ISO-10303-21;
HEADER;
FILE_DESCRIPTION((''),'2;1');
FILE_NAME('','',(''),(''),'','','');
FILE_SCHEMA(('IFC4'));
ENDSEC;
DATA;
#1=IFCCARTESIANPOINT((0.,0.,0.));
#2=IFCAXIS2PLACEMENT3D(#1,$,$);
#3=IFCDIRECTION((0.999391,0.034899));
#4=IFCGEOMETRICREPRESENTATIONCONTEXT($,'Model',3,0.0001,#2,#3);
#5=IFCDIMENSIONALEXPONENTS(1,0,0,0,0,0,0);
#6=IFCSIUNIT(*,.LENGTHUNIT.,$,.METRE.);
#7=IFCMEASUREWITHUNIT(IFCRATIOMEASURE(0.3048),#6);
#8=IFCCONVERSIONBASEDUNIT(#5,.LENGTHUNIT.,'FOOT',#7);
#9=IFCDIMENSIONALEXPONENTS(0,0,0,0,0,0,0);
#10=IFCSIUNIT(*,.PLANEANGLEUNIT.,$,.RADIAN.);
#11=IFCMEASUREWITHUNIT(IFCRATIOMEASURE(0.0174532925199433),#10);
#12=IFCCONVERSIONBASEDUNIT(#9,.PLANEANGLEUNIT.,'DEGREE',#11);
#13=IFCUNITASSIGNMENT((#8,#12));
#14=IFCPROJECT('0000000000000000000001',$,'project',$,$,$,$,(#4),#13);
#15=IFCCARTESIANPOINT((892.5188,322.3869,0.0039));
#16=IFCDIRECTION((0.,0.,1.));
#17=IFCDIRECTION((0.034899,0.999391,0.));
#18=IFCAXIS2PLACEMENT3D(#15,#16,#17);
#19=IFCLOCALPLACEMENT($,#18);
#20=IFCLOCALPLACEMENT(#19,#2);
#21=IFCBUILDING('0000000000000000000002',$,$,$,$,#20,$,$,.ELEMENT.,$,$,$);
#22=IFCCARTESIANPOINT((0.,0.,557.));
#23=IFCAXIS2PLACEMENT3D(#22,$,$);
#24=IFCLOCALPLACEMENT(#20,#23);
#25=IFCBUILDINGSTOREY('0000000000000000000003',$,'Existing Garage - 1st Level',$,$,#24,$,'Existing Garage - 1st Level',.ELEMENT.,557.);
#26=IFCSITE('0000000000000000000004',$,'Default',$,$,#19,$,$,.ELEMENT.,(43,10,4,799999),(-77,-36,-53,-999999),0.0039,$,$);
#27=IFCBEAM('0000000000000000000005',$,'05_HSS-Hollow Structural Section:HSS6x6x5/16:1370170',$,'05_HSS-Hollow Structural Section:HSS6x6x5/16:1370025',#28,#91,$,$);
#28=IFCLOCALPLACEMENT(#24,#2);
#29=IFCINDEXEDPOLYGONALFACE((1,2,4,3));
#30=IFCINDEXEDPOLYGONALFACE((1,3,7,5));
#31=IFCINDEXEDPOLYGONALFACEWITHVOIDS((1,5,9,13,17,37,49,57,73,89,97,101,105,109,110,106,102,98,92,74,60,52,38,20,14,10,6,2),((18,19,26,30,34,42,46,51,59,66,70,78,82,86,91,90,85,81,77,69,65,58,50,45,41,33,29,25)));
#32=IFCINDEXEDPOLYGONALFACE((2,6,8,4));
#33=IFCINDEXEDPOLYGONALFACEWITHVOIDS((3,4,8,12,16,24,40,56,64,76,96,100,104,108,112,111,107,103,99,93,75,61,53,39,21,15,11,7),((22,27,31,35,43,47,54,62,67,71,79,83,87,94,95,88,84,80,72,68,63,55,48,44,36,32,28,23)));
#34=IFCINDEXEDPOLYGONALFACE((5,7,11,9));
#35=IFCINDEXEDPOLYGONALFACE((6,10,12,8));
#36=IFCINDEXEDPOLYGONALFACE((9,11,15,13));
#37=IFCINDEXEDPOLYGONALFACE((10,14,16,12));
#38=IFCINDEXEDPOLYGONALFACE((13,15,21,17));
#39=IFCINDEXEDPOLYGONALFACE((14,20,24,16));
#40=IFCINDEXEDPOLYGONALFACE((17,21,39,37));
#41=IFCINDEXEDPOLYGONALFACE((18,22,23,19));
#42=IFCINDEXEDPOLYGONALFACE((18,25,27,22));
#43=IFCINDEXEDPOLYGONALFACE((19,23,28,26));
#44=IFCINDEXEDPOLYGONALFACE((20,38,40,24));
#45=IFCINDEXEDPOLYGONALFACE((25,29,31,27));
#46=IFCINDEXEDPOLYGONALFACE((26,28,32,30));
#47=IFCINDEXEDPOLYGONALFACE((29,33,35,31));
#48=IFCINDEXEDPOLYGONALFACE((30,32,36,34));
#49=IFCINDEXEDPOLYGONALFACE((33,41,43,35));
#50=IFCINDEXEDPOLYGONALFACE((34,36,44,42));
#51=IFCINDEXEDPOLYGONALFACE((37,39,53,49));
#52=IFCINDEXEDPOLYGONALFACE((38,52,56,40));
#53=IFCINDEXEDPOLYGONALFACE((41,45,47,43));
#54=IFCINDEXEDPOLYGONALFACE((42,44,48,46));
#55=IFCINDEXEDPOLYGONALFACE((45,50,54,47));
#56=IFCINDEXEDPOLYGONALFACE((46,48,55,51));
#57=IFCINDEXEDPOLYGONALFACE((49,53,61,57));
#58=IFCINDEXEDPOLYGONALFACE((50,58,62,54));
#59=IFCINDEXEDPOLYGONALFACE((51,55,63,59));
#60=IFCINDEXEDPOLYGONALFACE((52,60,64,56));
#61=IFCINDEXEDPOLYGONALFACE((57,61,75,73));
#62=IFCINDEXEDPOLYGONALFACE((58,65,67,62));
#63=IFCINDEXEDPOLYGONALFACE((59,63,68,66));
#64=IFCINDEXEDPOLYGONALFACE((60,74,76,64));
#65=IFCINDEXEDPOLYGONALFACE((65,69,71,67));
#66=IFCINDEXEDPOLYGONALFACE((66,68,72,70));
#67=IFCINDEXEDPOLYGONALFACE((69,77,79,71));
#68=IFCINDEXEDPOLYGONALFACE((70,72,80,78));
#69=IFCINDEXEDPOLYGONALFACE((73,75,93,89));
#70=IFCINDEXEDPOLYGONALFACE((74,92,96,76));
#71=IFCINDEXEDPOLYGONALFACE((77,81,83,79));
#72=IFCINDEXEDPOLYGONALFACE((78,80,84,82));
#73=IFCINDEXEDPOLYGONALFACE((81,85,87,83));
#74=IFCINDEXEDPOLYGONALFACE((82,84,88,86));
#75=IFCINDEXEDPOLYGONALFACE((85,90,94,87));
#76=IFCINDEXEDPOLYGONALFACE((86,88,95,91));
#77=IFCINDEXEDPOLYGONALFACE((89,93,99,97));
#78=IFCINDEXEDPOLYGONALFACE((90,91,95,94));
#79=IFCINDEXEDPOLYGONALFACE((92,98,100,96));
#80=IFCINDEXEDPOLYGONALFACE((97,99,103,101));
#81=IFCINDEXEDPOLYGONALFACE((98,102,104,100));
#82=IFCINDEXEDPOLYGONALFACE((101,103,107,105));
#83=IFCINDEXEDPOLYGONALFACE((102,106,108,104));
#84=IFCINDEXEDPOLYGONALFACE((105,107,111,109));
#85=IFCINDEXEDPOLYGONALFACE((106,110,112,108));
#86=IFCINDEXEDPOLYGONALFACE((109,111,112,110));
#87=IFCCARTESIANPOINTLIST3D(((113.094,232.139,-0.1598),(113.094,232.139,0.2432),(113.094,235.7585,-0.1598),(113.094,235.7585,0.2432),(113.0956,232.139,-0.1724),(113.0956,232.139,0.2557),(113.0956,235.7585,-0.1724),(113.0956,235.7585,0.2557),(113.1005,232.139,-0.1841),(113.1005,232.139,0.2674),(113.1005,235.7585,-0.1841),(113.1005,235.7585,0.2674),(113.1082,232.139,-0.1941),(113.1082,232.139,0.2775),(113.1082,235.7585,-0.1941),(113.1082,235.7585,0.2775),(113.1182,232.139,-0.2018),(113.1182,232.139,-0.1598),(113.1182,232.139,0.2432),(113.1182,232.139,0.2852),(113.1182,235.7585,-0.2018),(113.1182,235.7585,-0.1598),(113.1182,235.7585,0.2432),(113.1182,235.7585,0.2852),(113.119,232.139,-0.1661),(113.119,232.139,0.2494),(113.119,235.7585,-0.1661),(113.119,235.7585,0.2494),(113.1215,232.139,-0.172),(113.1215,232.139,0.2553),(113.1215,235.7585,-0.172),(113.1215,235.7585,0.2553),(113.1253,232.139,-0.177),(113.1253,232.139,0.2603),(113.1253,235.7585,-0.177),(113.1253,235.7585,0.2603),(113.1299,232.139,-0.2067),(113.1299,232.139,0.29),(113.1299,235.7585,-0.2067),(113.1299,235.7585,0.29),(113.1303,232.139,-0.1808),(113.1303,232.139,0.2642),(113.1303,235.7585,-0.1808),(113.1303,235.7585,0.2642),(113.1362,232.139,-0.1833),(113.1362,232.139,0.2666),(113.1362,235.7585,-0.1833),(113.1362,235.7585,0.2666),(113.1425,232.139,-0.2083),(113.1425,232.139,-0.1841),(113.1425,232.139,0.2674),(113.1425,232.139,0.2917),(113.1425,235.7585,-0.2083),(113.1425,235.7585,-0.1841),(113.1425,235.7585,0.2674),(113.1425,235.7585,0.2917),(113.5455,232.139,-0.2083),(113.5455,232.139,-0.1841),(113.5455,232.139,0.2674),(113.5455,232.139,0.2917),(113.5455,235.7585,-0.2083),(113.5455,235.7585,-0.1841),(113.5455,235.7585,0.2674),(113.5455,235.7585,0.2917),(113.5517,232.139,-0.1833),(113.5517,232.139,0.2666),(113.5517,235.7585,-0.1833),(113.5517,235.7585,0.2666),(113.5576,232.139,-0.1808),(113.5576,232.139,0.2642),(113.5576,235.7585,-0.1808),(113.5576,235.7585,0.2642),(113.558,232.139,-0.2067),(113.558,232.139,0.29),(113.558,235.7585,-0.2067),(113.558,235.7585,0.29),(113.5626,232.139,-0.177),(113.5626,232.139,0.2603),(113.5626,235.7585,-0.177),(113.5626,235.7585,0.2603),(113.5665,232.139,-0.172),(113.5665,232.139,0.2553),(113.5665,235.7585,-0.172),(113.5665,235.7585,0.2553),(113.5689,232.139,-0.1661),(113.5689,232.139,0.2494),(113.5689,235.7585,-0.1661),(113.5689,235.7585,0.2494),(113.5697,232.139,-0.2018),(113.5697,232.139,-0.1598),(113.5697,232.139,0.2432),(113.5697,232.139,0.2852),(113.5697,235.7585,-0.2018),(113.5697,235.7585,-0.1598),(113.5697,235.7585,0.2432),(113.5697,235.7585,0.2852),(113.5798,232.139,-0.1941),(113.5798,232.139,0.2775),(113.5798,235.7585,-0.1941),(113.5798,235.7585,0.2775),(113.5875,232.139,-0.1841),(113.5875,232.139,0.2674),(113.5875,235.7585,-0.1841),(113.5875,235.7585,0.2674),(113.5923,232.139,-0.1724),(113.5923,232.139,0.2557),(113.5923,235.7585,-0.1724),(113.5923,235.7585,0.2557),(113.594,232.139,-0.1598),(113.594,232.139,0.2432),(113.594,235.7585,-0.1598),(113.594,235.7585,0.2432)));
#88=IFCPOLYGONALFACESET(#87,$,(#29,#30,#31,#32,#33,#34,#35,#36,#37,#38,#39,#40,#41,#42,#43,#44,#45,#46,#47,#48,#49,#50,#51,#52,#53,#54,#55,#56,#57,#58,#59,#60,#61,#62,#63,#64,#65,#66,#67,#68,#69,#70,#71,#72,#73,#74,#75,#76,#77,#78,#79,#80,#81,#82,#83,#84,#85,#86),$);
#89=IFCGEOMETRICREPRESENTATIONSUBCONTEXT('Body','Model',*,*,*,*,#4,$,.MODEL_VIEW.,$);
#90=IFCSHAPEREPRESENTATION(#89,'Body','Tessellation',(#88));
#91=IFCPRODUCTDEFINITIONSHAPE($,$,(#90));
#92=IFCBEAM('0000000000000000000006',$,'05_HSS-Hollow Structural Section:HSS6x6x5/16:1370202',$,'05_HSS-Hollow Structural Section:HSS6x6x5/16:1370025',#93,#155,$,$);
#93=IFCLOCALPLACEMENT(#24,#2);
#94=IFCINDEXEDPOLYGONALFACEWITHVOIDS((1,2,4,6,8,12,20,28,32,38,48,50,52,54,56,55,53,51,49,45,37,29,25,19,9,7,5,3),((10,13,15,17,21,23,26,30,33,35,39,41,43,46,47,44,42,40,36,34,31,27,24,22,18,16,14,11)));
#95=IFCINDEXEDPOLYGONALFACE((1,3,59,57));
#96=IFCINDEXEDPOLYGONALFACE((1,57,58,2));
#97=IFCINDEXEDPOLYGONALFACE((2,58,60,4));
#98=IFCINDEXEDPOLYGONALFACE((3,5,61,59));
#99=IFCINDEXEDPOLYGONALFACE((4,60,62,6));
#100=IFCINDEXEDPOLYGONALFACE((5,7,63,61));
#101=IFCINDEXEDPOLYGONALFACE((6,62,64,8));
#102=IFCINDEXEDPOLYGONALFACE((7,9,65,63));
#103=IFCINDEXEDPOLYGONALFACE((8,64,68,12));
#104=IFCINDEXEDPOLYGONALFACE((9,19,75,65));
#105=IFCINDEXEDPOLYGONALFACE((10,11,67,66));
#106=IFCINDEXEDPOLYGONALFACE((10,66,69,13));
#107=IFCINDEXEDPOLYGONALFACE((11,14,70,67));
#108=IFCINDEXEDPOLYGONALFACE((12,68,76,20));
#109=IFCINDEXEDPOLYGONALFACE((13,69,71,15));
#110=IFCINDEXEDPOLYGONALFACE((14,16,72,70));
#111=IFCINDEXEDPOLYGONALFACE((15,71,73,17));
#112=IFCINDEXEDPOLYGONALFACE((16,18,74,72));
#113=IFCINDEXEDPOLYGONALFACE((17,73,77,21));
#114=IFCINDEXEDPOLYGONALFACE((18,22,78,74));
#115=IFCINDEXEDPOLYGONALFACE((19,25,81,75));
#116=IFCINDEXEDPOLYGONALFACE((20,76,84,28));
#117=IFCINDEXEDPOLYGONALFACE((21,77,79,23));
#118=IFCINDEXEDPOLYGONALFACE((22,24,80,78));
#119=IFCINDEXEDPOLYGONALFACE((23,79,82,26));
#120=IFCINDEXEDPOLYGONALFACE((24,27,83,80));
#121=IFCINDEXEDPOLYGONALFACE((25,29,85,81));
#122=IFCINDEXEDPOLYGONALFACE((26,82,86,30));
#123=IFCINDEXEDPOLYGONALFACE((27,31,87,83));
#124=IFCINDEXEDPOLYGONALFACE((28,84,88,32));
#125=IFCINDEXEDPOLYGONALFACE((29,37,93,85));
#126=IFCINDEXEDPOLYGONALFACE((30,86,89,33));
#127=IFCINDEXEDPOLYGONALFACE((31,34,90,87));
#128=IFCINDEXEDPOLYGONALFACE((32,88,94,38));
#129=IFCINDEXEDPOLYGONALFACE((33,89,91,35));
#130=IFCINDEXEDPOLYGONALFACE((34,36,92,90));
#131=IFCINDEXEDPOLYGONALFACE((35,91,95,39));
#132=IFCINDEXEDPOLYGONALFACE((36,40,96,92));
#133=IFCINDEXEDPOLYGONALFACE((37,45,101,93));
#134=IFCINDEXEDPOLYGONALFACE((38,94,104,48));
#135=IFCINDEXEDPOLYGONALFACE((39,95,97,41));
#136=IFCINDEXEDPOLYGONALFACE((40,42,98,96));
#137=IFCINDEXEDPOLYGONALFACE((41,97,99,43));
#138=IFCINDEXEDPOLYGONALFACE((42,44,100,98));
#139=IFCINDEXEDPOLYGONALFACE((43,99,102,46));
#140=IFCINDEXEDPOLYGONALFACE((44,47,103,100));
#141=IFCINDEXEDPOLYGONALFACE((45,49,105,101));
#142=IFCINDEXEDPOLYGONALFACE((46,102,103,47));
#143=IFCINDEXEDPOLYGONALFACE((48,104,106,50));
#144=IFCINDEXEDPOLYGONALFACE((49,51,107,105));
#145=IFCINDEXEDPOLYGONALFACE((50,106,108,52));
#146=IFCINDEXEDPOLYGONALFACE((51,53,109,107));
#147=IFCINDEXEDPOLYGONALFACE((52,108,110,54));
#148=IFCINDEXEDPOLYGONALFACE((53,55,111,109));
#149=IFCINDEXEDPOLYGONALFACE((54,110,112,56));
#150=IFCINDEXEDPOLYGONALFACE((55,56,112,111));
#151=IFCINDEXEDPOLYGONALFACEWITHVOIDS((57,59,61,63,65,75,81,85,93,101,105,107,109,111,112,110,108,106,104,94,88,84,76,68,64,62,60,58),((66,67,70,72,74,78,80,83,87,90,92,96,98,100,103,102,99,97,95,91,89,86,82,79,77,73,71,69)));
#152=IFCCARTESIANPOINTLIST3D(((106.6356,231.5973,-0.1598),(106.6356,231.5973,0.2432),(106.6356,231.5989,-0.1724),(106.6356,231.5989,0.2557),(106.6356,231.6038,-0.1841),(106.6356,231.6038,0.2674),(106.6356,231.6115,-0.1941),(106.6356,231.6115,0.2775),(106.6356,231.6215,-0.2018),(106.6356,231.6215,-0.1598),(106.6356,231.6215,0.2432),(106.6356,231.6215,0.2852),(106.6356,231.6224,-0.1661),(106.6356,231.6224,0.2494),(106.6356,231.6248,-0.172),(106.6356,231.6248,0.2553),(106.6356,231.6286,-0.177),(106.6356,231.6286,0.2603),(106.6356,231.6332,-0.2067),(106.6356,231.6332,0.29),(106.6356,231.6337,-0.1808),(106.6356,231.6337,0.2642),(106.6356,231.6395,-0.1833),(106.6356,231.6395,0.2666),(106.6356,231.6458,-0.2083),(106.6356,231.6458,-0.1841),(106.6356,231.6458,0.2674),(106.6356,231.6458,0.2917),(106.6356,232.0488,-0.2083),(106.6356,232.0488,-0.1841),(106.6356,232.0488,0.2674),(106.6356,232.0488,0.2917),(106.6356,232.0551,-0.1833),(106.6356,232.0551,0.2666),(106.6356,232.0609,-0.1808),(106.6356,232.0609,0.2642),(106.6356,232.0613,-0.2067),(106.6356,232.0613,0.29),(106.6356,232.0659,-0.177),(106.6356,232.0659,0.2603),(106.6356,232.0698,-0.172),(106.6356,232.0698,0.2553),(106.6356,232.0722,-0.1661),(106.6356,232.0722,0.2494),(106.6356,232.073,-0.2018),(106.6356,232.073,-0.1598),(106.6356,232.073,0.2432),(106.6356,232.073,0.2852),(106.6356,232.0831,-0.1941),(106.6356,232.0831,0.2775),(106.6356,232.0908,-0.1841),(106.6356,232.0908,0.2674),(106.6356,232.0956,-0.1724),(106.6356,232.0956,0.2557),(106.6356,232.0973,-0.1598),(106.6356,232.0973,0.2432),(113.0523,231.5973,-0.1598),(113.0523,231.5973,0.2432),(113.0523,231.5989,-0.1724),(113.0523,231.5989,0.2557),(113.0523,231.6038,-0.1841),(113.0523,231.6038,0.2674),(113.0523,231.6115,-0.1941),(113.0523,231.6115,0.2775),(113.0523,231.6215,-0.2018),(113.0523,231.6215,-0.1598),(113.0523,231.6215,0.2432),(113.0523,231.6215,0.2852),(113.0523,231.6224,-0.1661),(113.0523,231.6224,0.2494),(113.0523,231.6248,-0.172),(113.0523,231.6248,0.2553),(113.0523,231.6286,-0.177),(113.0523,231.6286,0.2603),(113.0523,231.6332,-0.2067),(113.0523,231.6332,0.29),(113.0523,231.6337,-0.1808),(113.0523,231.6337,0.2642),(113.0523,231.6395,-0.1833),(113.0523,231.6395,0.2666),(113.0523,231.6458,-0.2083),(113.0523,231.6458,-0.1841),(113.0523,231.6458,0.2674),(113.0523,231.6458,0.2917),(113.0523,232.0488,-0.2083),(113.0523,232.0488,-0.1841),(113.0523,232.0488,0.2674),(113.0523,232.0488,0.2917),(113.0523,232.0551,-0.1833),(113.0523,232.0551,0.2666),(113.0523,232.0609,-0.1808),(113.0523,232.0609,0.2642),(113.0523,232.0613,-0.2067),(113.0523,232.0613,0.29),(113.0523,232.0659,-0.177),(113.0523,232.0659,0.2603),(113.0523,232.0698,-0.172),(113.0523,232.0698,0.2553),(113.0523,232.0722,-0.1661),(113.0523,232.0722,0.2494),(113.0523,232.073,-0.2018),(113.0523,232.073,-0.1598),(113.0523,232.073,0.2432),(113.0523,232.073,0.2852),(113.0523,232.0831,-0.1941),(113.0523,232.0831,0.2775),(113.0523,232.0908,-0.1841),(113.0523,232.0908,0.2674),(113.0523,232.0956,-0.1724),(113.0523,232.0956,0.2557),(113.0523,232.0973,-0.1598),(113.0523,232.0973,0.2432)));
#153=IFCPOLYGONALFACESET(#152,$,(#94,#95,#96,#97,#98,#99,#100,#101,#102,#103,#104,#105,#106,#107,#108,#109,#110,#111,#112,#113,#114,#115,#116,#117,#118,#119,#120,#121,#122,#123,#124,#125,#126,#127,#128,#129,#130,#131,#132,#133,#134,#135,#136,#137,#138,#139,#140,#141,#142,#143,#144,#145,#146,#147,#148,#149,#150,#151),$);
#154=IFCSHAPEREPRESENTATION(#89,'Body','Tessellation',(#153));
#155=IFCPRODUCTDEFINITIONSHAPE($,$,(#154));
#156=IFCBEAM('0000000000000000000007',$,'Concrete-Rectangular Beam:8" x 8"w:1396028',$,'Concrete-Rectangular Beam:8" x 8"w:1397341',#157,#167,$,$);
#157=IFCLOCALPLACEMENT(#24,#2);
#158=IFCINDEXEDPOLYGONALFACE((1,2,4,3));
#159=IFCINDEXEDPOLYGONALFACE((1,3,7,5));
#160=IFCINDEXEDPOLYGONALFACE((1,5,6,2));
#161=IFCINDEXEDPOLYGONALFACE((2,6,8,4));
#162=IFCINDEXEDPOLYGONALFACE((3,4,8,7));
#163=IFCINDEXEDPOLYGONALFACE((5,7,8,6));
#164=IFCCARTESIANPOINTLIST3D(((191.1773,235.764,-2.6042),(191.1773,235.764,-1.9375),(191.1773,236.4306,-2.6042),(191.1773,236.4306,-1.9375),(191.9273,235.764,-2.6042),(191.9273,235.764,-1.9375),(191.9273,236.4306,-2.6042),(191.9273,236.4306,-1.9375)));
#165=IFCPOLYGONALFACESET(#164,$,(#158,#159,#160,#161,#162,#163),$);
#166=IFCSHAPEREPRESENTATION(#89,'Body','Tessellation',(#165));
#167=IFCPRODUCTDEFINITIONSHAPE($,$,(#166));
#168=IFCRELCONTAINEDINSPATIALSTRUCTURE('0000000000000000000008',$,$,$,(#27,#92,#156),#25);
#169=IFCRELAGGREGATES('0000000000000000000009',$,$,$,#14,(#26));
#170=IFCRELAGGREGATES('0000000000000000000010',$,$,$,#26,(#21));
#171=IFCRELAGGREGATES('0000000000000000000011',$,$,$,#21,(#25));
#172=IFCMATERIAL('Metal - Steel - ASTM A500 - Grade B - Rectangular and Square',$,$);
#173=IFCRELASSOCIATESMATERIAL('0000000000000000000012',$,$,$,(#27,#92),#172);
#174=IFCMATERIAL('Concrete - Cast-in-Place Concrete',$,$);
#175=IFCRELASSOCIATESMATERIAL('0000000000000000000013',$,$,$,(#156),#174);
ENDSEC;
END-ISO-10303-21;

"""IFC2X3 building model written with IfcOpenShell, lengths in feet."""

from ifc_helpers import new_model, entity, si_unit, converted_unit, direction, frame, frame_2d, origin, origin_2d_with_axis, place, context, subcontext, project, spatial, polyline, circle_curve, parameter, trimmed, segment, composite_curve, rectangle, outline, extrude, material, element, save


model = new_model("IFC2X3")

# Units and contexts
model_context = context("Model", 3, precision=0.0001, world=origin(), true_north=direction((0.999391, 0.034899)))
body_context = subcontext(model_context, "Body", "Model", "MODEL_VIEW")
ifc_project = project(units=[converted_unit("LENGTHUNIT", "FOOT", entity("IfcRatioMeasure", 0.3048), si_unit("LENGTHUNIT", "METRE"), dimensions=[1, 0, 0, 0, 0, 0, 0]), converted_unit("PLANEANGLEUNIT", "DEGREE", entity("IfcRatioMeasure", 0.0174532925199433), si_unit("PLANEANGLEUNIT", "RADIAN"), dimensions=[0, 0, 0, 0, 0, 0, 0])], contexts=[model_context])

# Site, building, storey
site_placement = place(None, frame((892.5188, 322.3869, 0.0039), z_axis=(0.0, 0.0, 1.0), x_axis=(0.034899, 0.999391, 0.0)))
site = spatial("IfcSite", under=ifc_project, at=site_placement, Name="Default", CompositionType="ELEMENT", RefLatitude=(43, 10, 4, 799999), RefLongitude=(-77, -36, -53, -999999), RefElevation=0.0039)
building_placement = place(site_placement, origin())
building = spatial("IfcBuilding", under=site, at=building_placement, CompositionType="ELEMENT")
storey_placement = place(building_placement, frame((0.0, 0.0, 557.0)))
storey = spatial("IfcBuildingStorey", under=building, at=storey_placement, Name="Existing Garage - 1st Level", LongName="Existing Garage - 1st Level", CompositionType="ELEMENT", Elevation=557.0)

# Beams
ifc_material_1 = material(Name="Metal - Steel - ASTM A500 - Grade B - Rectangular and Square")
beam_1_placement = place(storey_placement, frame((113.344, 231.8473, 0.2917), z_axis=(0.0, 0.0, 1.0), x_axis=(0.0, 1.0, 0.0)))
element("IfcBeam", 1, at=beam_1_placement, inside=storey, material=ifc_material_1, Name="05_HSS-Hollow Structural Section:HSS6x6x5/16:1370170", ObjectType="05_HSS-Hollow Structural Section:HSS6x6x5/16:1370025", context=body_context, shape_type="SweptSolid", body=[
    extrude(outline(composite_curve([segment(trimmed(circle_curve(frame_2d((-0.2015, -0.2015), x_axis=(1.0, 0.0)), 0.0485), [parameter(180.0)], [parameter(270.0)], True, "PARAMETER"), True, "CONTINUOUS"), segment(polyline([(-0.2015, -0.25), (0.2015, -0.25)]), True, "CONTINUOUS"), segment(trimmed(circle_curve(frame_2d((0.2015, -0.2015), x_axis=(1.0, 0.0)), 0.0485), [parameter(270.0)], [parameter(0.0)], True, "PARAMETER"), True, "CONTINUOUS"), segment(polyline([(0.25, -0.2015), (0.25, 0.2015)]), True, "CONTINUOUS"), segment(trimmed(circle_curve(frame_2d((0.2015, 0.2015), x_axis=(1.0, 0.0)), 0.0485), [parameter(360.0)], [parameter(90.0)], True, "PARAMETER"), True, "CONTINUOUS"), segment(polyline([(0.2015, 0.25), (-0.2015, 0.25)]), True, "CONTINUOUS"), segment(trimmed(circle_curve(frame_2d((-0.2015, 0.2015), x_axis=(1.0, 0.0)), 0.0485), [parameter(90.0)], [parameter(180.0)], True, "PARAMETER"), True, "CONTINUOUS"), segment(polyline([(-0.25, 0.2015), (-0.25, -0.2015)]), True, "CONTINUOUS")], self_intersect=False), holes=[composite_curve([segment(polyline([(0.2015, -0.2257), (-0.2015, -0.2257)]), True, "CONTINUOUS"), segment(trimmed(circle_curve(frame_2d((-0.2015, -0.2015), x_axis=(1.0, 0.0)), 0.0243), [parameter(180.0)], [parameter(270.0)], True, "PARAMETER"), False, "CONTINUOUS"), segment(polyline([(-0.2257, -0.2015), (-0.2257, 0.2015)]), True, "CONTINUOUS"), segment(trimmed(circle_curve(frame_2d((-0.2015, 0.2015), x_axis=(1.0, 0.0)), 0.0243), [parameter(90.0)], [parameter(180.0)], True, "PARAMETER"), False, "CONTINUOUS"), segment(polyline([(-0.2015, 0.2258), (0.2015, 0.2258)]), True, "CONTINUOUS"), segment(trimmed(circle_curve(frame_2d((0.2015, 0.2015), x_axis=(1.0, 0.0)), 0.0243), [parameter(0.0)], [parameter(90.0)], True, "PARAMETER"), False, "CONTINUOUS"), segment(polyline([(0.2258, 0.2015), (0.2258, -0.2015)]), True, "CONTINUOUS"), segment(trimmed(circle_curve(frame_2d((0.2015, -0.2015), x_axis=(1.0, 0.0)), 0.0243), [parameter(270.0)], [parameter(0.0)], True, "PARAMETER"), False, "CONTINUOUS")], self_intersect=False)]), frame((0.2917, 0.0, -0.25), z_axis=(1.0, 0.0, 0.0), x_axis=(0.0, -1.0, 0.0)), (0.0, 0.0, 1.0), 3.6195),
])
beam_2_placement = place(storey_placement, frame((113.344, 231.8473, 0.2917), z_axis=(0.0, 0.0, 1.0), x_axis=(-1.0, 0.0, 0.0)))
element("IfcBeam", 2, at=beam_2_placement, inside=storey, material=ifc_material_1, Name="05_HSS-Hollow Structural Section:HSS6x6x5/16:1370202", ObjectType="05_HSS-Hollow Structural Section:HSS6x6x5/16:1370025", context=body_context, shape_type="SweptSolid", body=[
    extrude(outline(composite_curve([segment(trimmed(circle_curve(frame_2d((-0.2015, -0.2015), x_axis=(1.0, 0.0)), 0.0485), [parameter(180.0)], [parameter(270.0)], True, "PARAMETER"), True, "CONTINUOUS"), segment(polyline([(-0.2015, -0.25), (0.2015, -0.25)]), True, "CONTINUOUS"), segment(trimmed(circle_curve(frame_2d((0.2015, -0.2015), x_axis=(1.0, 0.0)), 0.0485), [parameter(270.0)], [parameter(0.0)], True, "PARAMETER"), True, "CONTINUOUS"), segment(polyline([(0.25, -0.2015), (0.25, 0.2015)]), True, "CONTINUOUS"), segment(trimmed(circle_curve(frame_2d((0.2015, 0.2015), x_axis=(1.0, 0.0)), 0.0485), [parameter(360.0)], [parameter(90.0)], True, "PARAMETER"), True, "CONTINUOUS"), segment(polyline([(0.2015, 0.25), (-0.2015, 0.25)]), True, "CONTINUOUS"), segment(trimmed(circle_curve(frame_2d((-0.2015, 0.2015), x_axis=(1.0, 0.0)), 0.0485), [parameter(90.0)], [parameter(180.0)], True, "PARAMETER"), True, "CONTINUOUS"), segment(polyline([(-0.25, 0.2015), (-0.25, -0.2015)]), True, "CONTINUOUS")], self_intersect=False), holes=[composite_curve([segment(polyline([(0.2015, -0.2257), (-0.2015, -0.2257)]), True, "CONTINUOUS"), segment(trimmed(circle_curve(frame_2d((-0.2015, -0.2015), x_axis=(1.0, 0.0)), 0.0243), [parameter(180.0)], [parameter(270.0)], True, "PARAMETER"), False, "CONTINUOUS"), segment(polyline([(-0.2258, -0.2015), (-0.2258, 0.2015)]), True, "CONTINUOUS"), segment(trimmed(circle_curve(frame_2d((-0.2015, 0.2015), x_axis=(1.0, 0.0)), 0.0243), [parameter(90.0)], [parameter(180.0)], True, "PARAMETER"), False, "CONTINUOUS"), segment(polyline([(-0.2015, 0.2258), (0.2015, 0.2258)]), True, "CONTINUOUS"), segment(trimmed(circle_curve(frame_2d((0.2015, 0.2015), x_axis=(1.0, 0.0)), 0.0243), [parameter(0.0)], [parameter(90.0)], True, "PARAMETER"), False, "CONTINUOUS"), segment(polyline([(0.2257, 0.2015), (0.2257, -0.2015)]), True, "CONTINUOUS"), segment(trimmed(circle_curve(frame_2d((0.2015, -0.2015), x_axis=(1.0, 0.0)), 0.0243), [parameter(270.0)], [parameter(0.0)], True, "PARAMETER"), False, "CONTINUOUS")], self_intersect=False)]), frame((0.2917, 0.0, -0.25), z_axis=(1.0, 0.0, 0.0), x_axis=(0.0, -1.0, 0.0)), (0.0, 0.0, 1.0), 6.4167),
])
ifc_material_2 = material(Name="Concrete - Cast-in-Place Concrete")
beam_3_placement = place(storey_placement, frame((192.9273, 236.0973, -1.9375), z_axis=(0.0, 0.0, 1.0), x_axis=(-1.0, 0.0, 0.0)))
element("IfcBeam", 3, at=beam_3_placement, inside=storey, material=ifc_material_2, Name="Concrete-Rectangular Beam:8\" x 8\"w:1396028", ObjectType="Concrete-Rectangular Beam:8\" x 8\"w:1397341", context=body_context, shape_type="SweptSolid", body=[
    extrude(rectangle(XDim=0.6667, YDim=0.6667, at=origin_2d_with_axis()), frame((1.0, 0.0, -0.3333), z_axis=(1.0, 0.0, 0.0), x_axis=(0.0, 0.0, -1.0)), (0.0, 0.0, 1.0), 0.75),
])

save(model, "model.ifc")
